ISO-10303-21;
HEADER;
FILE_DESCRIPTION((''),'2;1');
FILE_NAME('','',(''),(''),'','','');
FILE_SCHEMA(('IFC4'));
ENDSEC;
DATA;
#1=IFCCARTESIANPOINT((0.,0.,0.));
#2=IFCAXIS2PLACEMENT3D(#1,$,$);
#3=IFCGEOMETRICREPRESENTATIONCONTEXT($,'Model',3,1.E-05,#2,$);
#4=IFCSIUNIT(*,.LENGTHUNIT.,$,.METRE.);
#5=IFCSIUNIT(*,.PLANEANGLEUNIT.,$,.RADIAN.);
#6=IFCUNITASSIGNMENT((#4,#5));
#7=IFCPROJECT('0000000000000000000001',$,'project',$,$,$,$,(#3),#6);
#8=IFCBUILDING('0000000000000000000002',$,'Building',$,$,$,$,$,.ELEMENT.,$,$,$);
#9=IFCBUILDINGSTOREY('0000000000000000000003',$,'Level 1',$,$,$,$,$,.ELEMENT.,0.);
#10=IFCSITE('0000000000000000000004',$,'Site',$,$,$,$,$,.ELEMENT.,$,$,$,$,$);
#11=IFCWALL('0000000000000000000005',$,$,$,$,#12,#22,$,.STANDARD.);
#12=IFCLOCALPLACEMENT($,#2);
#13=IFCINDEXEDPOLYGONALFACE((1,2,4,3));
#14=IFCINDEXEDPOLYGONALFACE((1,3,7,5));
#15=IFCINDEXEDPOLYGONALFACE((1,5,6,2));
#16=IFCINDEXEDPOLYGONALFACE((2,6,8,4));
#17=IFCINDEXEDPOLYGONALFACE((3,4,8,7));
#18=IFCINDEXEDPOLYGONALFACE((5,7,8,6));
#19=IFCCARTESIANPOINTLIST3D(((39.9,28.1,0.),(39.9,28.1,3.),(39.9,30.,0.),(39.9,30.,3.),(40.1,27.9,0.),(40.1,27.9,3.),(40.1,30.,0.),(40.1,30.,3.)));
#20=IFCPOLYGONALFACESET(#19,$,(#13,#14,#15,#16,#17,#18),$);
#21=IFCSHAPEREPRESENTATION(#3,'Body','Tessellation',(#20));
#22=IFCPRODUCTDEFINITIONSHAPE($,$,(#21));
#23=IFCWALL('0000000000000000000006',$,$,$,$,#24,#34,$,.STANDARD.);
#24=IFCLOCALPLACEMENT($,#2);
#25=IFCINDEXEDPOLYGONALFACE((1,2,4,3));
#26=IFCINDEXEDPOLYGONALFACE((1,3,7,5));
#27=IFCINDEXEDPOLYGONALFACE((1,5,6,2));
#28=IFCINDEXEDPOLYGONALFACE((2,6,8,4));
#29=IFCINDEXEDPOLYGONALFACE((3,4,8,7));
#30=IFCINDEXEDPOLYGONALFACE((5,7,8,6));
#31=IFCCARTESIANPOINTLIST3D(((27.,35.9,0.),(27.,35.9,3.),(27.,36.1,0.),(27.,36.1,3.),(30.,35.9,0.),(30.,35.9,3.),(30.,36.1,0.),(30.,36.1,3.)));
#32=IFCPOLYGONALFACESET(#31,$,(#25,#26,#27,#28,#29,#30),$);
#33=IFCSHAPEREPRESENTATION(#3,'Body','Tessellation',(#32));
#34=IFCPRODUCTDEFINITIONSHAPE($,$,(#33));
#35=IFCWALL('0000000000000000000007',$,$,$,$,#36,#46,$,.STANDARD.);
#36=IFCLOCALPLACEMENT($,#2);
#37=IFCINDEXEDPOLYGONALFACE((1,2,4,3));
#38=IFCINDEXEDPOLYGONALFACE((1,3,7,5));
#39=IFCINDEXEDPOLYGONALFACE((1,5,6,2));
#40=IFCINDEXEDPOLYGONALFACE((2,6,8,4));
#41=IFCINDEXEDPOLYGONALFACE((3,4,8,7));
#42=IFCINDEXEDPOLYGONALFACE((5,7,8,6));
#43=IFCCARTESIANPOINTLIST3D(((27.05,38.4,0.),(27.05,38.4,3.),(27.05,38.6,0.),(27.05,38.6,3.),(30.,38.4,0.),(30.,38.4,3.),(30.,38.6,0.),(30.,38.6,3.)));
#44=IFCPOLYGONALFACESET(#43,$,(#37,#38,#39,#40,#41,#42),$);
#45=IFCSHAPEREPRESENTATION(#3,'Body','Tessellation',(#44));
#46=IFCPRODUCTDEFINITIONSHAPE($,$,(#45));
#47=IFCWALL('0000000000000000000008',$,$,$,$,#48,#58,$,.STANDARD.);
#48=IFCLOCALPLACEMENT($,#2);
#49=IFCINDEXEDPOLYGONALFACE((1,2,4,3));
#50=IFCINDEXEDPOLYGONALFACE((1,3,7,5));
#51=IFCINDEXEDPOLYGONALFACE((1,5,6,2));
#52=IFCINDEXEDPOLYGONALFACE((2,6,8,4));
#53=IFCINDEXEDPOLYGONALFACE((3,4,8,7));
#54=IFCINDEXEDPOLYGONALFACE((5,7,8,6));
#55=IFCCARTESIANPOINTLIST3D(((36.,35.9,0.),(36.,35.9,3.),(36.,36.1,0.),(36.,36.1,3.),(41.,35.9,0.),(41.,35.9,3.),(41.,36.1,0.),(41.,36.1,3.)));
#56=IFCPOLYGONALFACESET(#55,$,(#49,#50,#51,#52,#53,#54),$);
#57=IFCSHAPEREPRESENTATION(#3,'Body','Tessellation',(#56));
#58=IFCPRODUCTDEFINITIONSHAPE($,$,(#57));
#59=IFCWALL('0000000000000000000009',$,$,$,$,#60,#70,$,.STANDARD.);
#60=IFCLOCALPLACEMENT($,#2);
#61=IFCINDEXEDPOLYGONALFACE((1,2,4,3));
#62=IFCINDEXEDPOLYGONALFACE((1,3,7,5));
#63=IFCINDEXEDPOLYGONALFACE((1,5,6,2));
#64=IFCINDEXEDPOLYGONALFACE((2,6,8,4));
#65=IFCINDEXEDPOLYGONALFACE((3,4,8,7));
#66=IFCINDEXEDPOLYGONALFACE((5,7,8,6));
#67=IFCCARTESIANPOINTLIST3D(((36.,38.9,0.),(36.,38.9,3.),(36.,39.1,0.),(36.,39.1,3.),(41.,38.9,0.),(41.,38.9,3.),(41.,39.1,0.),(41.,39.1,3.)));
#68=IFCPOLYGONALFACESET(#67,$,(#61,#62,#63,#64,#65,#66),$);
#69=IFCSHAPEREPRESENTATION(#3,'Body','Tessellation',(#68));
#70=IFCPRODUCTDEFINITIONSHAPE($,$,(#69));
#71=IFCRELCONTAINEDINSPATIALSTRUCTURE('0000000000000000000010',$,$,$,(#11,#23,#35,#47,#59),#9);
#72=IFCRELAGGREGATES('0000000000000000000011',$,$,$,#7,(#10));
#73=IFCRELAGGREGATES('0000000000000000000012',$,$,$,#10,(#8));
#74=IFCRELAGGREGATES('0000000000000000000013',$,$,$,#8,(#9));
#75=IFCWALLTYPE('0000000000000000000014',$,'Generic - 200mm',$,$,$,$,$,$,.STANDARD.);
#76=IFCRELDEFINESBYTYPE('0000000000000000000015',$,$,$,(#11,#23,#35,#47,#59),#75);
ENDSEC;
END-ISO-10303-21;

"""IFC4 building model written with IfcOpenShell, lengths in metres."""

from ifc_helpers import new_model, si_unit, frame, frame_2d, origin, place, context, project, spatial, polyline, rectangle, outline, extrude, type_object, element, save


model = new_model("IFC4")

# Units and contexts
model_context = context("Model", 3, precision=1e-05, world=origin())
ifc_project = project(units=[si_unit("LENGTHUNIT", "METRE"), si_unit("PLANEANGLEUNIT", "RADIAN")], contexts=[model_context])

# Site, building, storey
site = spatial("IfcSite", under=ifc_project, Name="Site", CompositionType="ELEMENT")
building = spatial("IfcBuilding", under=site, Name="Building", CompositionType="ELEMENT")
storey = spatial("IfcBuildingStorey", under=building, Name="Level 1", CompositionType="ELEMENT", Elevation=0.0)

# Shared definitions
wall_type = type_object("IfcWallType", Name="Generic - 200mm", PredefinedType="STANDARD")

# Walls
wall_1_placement = place(None, frame((40.0, 28.0, 0.0), z_axis=(0.0, 0.0, 1.0), x_axis=(0.0, 1.0, 0.0)))
element("IfcWall", 1, at=wall_1_placement, inside=storey, type_object=wall_type, PredefinedType="STANDARD", context=model_context, shape_type="SweptSolid", body=[
    extrude(outline(polyline([(-0.1, -0.1), (2.0, -0.1), (2.0, 0.1), (0.1, 0.1), (-0.1, -0.1)])), origin(), (0.0, 0.0, 1.0), 3.0),
])
wall_2_placement = place(None, frame((27.0, 36.0, 0.0), z_axis=(0.0, 0.0, 1.0), x_axis=(1.0, 0.0, 0.0)))
element("IfcWall", 2, at=wall_2_placement, inside=storey, type_object=wall_type, PredefinedType="STANDARD", context=model_context, shape_type="SweptSolid", body=[
    extrude(rectangle(XDim=3.0, YDim=0.2, at=frame_2d((1.5, 0.0))), origin(), (0.0, 0.0, 1.0), 3.0),
])
wall_3_placement = place(None, frame((27.05, 38.5, 0.0), z_axis=(0.0, 0.0, 1.0), x_axis=(1.0, 0.0, 0.0)))
element("IfcWall", 3, at=wall_3_placement, inside=storey, type_object=wall_type, PredefinedType="STANDARD", context=model_context, shape_type="SweptSolid", body=[
    extrude(rectangle(XDim=2.95, YDim=0.2, at=frame_2d((1.475, 0.0))), origin(), (0.0, 0.0, 1.0), 3.0),
])
for number, where, z_axis, x_axis in (
    (4, (36.0, 36.0, 0.0), (0.0, 0.0, 1.0), (1.0, 0.0, 0.0)),
    (5, (36.0, 39.0, 0.0), (0.0, 0.0, 1.0), (1.0, 0.0, 0.0)),
):
    element("IfcWall", number, at=place(None, frame(where, z_axis=z_axis, x_axis=x_axis)), inside=storey, type_object=wall_type, PredefinedType="STANDARD", context=model_context, shape_type="SweptSolid", body=[
        extrude(rectangle(XDim=5.0, YDim=0.2, at=frame_2d((2.5, 0.0))), origin(), (0.0, 0.0, 1.0), 3.0),
    ])

save(model, "model.ifc")
